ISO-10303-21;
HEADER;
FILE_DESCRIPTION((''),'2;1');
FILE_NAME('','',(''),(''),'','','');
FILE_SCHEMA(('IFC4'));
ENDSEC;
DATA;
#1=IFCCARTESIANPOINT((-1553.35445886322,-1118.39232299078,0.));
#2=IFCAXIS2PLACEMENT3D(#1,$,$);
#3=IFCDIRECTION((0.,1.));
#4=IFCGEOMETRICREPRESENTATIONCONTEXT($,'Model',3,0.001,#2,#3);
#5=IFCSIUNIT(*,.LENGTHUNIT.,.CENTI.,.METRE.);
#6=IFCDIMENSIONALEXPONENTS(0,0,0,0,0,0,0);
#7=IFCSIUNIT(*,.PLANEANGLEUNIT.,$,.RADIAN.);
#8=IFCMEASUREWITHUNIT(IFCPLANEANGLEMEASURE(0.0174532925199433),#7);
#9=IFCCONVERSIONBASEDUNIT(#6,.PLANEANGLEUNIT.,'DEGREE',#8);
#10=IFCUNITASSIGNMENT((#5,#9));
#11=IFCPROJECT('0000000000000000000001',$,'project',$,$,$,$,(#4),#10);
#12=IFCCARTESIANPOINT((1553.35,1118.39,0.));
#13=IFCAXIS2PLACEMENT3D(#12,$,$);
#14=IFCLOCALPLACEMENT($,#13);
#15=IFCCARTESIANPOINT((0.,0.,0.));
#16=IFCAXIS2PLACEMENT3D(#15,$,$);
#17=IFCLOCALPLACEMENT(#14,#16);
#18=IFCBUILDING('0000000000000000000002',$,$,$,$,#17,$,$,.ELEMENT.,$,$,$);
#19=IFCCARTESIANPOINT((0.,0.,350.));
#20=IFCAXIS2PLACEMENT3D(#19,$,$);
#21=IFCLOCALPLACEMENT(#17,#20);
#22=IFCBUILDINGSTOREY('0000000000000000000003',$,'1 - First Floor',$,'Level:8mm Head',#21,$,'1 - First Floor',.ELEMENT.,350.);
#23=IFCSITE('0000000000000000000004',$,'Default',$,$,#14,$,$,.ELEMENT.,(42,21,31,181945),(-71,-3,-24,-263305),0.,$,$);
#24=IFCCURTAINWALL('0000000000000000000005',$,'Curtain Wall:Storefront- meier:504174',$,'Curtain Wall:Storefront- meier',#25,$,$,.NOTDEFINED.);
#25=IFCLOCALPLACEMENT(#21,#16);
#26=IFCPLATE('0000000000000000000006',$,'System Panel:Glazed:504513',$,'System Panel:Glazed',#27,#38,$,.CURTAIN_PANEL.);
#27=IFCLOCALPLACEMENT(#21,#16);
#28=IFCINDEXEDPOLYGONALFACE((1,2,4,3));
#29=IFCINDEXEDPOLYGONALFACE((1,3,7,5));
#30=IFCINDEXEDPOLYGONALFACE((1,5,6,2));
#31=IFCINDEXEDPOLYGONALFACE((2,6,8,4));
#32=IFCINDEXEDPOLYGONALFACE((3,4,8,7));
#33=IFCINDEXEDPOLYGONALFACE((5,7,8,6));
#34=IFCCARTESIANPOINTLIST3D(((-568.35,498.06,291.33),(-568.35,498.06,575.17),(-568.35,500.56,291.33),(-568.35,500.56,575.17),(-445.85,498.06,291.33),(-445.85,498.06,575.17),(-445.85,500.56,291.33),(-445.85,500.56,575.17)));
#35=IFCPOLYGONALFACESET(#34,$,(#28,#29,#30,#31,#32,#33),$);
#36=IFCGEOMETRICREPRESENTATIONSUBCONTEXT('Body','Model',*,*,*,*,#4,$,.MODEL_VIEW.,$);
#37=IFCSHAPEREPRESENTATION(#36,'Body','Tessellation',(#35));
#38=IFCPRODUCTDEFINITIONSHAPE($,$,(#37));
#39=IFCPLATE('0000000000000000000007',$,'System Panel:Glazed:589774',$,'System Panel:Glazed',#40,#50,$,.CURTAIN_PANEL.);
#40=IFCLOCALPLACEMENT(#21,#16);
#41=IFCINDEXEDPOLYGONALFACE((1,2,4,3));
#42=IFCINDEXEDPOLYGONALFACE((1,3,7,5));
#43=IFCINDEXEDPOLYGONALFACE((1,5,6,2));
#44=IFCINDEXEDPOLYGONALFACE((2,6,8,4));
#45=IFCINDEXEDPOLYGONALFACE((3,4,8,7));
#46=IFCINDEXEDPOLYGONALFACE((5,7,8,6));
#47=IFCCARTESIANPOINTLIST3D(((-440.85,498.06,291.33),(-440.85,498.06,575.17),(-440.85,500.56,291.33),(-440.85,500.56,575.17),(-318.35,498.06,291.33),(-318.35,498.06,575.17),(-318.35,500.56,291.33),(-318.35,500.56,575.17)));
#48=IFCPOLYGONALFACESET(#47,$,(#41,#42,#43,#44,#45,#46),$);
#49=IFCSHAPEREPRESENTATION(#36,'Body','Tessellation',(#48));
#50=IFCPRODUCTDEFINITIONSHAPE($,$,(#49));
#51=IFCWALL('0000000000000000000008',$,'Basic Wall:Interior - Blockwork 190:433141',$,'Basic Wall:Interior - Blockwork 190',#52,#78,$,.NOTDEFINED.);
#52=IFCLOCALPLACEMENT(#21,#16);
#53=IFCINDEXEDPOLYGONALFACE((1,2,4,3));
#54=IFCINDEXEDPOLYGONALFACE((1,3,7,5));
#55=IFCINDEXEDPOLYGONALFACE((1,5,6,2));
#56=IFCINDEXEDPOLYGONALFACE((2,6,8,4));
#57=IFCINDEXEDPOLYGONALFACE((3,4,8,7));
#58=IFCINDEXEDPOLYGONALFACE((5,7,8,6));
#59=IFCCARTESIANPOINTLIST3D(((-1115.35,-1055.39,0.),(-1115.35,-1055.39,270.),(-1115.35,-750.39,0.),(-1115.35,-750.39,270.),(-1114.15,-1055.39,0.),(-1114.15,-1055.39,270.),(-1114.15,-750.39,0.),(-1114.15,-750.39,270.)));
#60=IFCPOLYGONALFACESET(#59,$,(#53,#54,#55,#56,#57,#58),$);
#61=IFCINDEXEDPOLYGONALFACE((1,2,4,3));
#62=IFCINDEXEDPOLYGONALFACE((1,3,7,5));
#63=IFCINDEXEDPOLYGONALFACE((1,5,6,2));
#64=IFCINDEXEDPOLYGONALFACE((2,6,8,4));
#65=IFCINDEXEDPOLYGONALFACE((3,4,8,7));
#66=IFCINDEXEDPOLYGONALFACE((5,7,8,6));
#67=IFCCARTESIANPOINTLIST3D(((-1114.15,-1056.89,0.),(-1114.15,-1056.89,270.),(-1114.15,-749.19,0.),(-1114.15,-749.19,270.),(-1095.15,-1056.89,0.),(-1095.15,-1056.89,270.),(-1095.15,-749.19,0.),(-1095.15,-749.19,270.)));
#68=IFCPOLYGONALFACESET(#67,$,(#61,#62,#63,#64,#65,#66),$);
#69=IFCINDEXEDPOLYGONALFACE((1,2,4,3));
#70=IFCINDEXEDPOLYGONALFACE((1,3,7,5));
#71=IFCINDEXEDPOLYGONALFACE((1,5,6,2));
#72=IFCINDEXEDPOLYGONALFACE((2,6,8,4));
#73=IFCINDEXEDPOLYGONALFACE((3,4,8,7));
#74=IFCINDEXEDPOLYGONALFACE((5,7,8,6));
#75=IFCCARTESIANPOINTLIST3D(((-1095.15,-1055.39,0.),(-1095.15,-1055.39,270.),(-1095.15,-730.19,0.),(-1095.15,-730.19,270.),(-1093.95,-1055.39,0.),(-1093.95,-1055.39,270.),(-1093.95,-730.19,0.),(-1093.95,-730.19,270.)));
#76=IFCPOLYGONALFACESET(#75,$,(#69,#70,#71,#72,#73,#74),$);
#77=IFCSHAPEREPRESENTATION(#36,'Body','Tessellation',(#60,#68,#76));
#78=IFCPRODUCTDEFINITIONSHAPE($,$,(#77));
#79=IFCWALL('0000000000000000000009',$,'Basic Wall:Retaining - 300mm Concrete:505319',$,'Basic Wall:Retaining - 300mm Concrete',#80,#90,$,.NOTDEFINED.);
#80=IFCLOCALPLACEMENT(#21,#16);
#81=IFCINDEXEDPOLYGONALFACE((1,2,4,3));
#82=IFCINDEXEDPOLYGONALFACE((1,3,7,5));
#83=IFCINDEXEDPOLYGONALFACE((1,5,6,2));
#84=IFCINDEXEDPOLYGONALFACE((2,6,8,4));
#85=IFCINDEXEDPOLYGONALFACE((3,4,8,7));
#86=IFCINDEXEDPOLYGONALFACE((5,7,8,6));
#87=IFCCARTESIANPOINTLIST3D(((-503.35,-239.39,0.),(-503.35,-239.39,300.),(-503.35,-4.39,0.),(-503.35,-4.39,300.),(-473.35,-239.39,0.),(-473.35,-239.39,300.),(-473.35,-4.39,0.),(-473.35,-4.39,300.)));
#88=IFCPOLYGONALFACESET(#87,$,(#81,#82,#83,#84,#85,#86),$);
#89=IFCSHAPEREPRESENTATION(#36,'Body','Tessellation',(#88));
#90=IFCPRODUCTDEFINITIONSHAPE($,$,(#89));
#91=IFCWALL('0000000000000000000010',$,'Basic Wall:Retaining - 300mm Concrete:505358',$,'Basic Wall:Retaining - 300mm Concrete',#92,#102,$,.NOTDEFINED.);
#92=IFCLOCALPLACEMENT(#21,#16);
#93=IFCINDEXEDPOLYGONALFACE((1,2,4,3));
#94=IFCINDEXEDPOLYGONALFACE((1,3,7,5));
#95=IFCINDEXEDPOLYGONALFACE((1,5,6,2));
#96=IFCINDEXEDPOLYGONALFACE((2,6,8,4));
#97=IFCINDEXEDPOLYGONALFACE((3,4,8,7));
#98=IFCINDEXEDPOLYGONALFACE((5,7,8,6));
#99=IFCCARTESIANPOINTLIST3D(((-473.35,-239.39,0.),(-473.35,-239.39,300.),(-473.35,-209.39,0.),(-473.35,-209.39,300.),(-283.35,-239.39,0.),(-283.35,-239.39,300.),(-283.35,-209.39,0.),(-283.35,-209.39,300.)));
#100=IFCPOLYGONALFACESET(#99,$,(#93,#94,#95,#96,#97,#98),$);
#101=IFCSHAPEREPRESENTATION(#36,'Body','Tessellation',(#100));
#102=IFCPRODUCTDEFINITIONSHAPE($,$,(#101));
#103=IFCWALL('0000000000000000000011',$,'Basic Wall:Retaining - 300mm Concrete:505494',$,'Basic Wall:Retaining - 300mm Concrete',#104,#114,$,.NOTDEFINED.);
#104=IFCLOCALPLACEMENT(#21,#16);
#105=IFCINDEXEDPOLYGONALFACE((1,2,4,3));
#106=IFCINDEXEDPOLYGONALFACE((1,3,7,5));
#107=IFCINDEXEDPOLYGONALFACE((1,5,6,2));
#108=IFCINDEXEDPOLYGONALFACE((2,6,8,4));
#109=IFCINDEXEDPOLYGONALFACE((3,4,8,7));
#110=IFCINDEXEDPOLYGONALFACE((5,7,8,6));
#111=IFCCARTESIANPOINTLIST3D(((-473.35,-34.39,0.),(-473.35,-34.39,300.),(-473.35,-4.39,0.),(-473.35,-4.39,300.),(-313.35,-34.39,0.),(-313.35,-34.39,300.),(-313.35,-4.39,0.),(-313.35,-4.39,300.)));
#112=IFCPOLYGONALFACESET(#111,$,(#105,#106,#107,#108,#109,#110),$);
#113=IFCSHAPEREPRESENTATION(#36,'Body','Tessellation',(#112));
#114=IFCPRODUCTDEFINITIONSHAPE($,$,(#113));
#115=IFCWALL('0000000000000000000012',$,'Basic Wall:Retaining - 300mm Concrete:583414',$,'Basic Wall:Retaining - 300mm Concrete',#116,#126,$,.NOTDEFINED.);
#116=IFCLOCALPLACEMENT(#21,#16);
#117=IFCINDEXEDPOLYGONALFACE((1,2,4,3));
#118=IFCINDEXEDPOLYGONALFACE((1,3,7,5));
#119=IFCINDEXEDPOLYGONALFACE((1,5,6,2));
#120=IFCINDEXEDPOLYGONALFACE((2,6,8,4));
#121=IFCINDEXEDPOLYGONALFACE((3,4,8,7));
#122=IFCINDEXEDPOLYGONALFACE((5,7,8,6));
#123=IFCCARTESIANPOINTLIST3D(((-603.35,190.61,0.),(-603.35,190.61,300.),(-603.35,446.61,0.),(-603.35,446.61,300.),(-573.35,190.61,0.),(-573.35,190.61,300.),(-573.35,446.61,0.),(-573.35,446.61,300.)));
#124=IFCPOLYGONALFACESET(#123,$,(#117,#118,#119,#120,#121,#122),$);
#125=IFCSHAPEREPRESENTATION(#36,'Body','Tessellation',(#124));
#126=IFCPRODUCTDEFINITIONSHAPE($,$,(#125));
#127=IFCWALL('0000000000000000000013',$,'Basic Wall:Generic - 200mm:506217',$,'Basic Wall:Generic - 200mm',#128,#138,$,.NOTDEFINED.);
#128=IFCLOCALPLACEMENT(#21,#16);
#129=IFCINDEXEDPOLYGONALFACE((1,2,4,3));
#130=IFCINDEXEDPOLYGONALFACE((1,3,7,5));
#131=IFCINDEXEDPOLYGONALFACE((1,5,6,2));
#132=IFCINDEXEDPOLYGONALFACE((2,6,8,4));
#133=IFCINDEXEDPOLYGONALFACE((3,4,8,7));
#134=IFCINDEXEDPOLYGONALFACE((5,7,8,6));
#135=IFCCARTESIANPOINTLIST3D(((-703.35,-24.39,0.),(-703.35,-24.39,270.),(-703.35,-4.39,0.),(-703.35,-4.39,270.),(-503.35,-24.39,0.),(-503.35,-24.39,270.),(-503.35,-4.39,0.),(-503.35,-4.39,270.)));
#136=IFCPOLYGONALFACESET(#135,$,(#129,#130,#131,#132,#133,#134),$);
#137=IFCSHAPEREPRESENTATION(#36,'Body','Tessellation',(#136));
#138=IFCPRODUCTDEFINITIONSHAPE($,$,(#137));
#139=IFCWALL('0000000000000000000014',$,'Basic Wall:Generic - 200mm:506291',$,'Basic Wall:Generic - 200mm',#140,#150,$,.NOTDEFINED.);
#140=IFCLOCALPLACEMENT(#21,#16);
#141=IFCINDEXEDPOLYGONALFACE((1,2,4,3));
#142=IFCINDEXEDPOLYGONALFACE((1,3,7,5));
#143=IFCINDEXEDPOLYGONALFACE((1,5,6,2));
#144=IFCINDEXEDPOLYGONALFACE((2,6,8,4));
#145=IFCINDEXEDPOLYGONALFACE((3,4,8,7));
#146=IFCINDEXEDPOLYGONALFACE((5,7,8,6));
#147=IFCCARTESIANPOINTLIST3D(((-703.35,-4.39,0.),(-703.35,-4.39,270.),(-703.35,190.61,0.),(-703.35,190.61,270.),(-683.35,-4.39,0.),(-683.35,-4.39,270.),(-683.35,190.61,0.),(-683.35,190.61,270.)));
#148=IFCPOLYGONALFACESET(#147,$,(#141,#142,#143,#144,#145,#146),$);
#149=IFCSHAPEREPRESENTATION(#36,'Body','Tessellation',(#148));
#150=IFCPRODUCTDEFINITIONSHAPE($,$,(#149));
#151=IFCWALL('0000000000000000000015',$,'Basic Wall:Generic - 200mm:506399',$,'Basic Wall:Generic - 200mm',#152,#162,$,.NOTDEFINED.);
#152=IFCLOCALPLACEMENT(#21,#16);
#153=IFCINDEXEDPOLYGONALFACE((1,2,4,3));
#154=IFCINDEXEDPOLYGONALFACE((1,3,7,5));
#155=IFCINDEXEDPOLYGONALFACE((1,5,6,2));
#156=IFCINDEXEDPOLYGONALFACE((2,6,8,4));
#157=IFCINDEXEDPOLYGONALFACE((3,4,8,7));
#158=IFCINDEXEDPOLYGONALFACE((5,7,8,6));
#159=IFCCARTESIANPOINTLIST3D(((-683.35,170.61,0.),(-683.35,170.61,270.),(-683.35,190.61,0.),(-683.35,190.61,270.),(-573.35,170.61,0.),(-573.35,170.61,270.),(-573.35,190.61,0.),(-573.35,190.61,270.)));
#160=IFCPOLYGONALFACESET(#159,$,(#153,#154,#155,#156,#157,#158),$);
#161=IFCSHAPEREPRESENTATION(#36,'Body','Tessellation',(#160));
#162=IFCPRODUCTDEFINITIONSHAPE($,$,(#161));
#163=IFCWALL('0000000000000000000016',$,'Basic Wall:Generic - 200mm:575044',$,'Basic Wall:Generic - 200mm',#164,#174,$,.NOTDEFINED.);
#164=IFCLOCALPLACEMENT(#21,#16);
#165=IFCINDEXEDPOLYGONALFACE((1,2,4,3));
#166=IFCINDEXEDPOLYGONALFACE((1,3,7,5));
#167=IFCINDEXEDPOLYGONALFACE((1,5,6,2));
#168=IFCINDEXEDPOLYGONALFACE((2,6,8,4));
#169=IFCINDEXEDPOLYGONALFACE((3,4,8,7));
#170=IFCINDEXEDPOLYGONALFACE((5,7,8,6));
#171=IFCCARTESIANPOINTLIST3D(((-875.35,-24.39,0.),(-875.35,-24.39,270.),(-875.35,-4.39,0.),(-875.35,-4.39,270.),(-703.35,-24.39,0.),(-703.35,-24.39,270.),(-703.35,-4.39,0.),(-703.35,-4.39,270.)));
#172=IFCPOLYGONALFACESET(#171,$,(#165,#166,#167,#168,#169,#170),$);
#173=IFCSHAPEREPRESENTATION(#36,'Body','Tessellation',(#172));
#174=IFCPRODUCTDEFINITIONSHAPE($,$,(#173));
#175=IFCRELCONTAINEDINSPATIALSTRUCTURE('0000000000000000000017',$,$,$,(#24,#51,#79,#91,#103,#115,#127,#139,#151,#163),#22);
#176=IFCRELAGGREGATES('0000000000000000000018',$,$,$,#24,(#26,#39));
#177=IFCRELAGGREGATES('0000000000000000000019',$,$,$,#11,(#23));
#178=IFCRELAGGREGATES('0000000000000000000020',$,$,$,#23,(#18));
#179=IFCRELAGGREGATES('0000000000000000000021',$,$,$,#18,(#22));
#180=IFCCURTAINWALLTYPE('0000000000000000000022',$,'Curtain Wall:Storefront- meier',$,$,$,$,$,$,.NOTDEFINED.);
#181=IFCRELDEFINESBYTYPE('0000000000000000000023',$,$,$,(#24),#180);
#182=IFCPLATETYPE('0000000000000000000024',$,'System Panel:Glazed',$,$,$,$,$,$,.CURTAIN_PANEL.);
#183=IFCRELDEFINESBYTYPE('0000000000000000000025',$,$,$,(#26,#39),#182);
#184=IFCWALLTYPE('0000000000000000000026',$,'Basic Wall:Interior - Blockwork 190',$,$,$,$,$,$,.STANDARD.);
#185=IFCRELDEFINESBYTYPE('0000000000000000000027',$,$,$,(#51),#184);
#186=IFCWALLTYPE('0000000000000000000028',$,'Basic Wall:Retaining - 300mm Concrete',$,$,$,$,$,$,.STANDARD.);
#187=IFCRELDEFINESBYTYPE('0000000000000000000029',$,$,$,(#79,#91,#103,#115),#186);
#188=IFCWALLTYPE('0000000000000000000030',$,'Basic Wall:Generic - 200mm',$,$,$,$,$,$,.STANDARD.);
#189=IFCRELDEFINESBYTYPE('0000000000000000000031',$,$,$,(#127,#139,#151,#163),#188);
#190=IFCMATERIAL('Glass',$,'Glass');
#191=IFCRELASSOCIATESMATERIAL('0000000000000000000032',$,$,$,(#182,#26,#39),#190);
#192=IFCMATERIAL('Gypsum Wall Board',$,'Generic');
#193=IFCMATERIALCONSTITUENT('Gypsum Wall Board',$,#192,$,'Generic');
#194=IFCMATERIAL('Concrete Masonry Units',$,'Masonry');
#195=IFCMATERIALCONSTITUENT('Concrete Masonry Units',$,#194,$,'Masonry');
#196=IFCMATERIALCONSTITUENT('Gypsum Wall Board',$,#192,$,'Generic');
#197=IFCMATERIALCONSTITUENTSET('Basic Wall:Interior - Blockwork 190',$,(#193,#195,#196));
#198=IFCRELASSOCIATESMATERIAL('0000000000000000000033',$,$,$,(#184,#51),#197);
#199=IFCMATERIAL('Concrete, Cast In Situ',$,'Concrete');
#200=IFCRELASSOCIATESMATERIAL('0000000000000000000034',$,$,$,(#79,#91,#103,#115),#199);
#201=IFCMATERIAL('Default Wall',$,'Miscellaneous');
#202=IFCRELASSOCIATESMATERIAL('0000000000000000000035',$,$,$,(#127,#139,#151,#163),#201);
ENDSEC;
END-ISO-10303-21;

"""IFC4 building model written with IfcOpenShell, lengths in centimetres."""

from ifc_helpers import new_model, entity, si_unit, converted_unit, direction, frame, origin, place, context, subcontext, project, spatial, indexed_curve, outline, extrude, source, transform, mapped, material, constituent, constituent_set, type_object, type_shapes, element, aggregate, save


model = new_model("IFC4")

# Units and contexts
model_context = context("Model", 3, precision=0.001, world=frame((-1553.35445886322, -1118.39232299078, 0.0)), true_north=direction((0.0, 1.0)))
body_context = subcontext(model_context, "Body", "Model", "MODEL_VIEW")
ifc_project = project(units=[si_unit("LENGTHUNIT", "METRE", prefix="CENTI"), converted_unit("PLANEANGLEUNIT", "DEGREE", entity("IfcPlaneAngleMeasure", 0.0174532925199433), si_unit("PLANEANGLEUNIT", "RADIAN"), dimensions=[0, 0, 0, 0, 0, 0, 0])], contexts=[model_context])

# Site, building, storey
site_placement = place(None, frame((1553.35, 1118.39, 0.0)))
site = spatial("IfcSite", under=ifc_project, at=site_placement, Name="Default", CompositionType="ELEMENT", RefLatitude=(42, 21, 31, 181945), RefLongitude=(-71, -3, -24, -263305), RefElevation=0.0)
building_placement = place(site_placement, origin())
building = spatial("IfcBuilding", under=site, at=building_placement, CompositionType="ELEMENT")
storey_placement = place(building_placement, frame((0.0, 0.0, 350.0)))
storey = spatial("IfcBuildingStorey", under=building, at=storey_placement, Name="1 - First Floor", ObjectType="Level:8mm Head", LongName="1 - First Floor", CompositionType="ELEMENT", Elevation=350.0)

# Curtain wall, plates
curtain_wall_type = type_object("IfcCurtainWallType", Name="Curtain Wall:Storefront- meier", PredefinedType="NOTDEFINED")
curtain_wall_placement = place(storey_placement, frame((0.0, 0.0, -350.0)))
curtain_wall = element("IfcCurtainWall", 1, at=curtain_wall_placement, inside=storey, type_object=curtain_wall_type, Name="Curtain Wall:Storefront- meier:504174", ObjectType="Curtain Wall:Storefront- meier", PredefinedType="NOTDEFINED")
ifc_material_1 = material(Name="Glass", Category="Glass")
plate_type_1 = type_object("IfcPlateType", Name="System Panel:Glazed", PredefinedType="CURTAIN_PANEL", material=ifc_material_1)
shared_shape_1 = source(origin(), body_context, "Body", "SweptSolid", [
    extrude(outline(indexed_curve([(-1.25, -61.25), (1.25, -61.25), (1.25, 61.25), (-1.25, 61.25), (-1.25, -61.25)], self_intersect=False)), frame((0.0, 3.7, 0.0), z_axis=(0.0, 0.0, 1.0), x_axis=(0.0, 1.0, 0.0)), (0.0, 0.0, 1.0), 283.83),
])
type_shapes(plate_type_1, [shared_shape_1])
plate_1_placement = place(curtain_wall_placement, frame((-507.1, 495.61, 641.33)))
plate_1 = element("IfcPlate", 2, at=plate_1_placement, type_object=plate_type_1, material=ifc_material_1, Name="System Panel:Glazed:504513", ObjectType="System Panel:Glazed", PredefinedType="CURTAIN_PANEL", context=body_context, shape_type="MappedRepresentation", body=[
    mapped(shared_shape_1, transform((0.0, 0.0, 0.0), scale=1.0)),
])
plate_2_placement = place(curtain_wall_placement, frame((-379.6, 495.61, 641.33)))
plate_2 = element("IfcPlate", 3, at=plate_2_placement, type_object=plate_type_1, material=ifc_material_1, Name="System Panel:Glazed:589774", ObjectType="System Panel:Glazed", PredefinedType="CURTAIN_PANEL", context=body_context, shape_type="MappedRepresentation", body=[
    mapped(shared_shape_1, transform((0.0, 0.0, 0.0), scale=1.0)),
])
aggregate(curtain_wall, [plate_1, plate_2])

# Shared definitions
ifc_material_2 = material(Name="Concrete Masonry Units", Category="Masonry")

# Shared definitions
ifc_material_3 = material(Name="Gypsum Wall Board", Category="Generic")
ifc_constituent_1 = constituent(ifc_material_3, Name="Gypsum Wall Board", Category="Generic")
ifc_constituent_2 = constituent(ifc_material_2, Name="Concrete Masonry Units", Category="Masonry")
ifc_constituent_3 = constituent(ifc_material_3, Name="Gypsum Wall Board", Category="Generic")
ifc_constituent_set_1 = constituent_set(constituents=[ifc_constituent_1, ifc_constituent_2, ifc_constituent_3], Name="Basic Wall:Interior - Blockwork 190")
wall_type_1 = type_object("IfcWallType", Name="Basic Wall:Interior - Blockwork 190", PredefinedType="STANDARD", material=ifc_constituent_set_1)

# Walls
wall_1_placement = place(storey_placement, frame((-1104.65, -750.39, 0.0), z_axis=(0.0, 0.0, 1.0), x_axis=(0.0, -1.0, 0.0)))
element("IfcWall", 4, at=wall_1_placement, inside=storey, type_object=wall_type_1, material=ifc_constituent_set_1, Name="Basic Wall:Interior - Blockwork 190:433141", ObjectType="Basic Wall:Interior - Blockwork 190", PredefinedType="NOTDEFINED", context=body_context, shape_type="SweptSolid", body=[
    extrude(outline(indexed_curve([(-0.6, -152.5), (0.6, -152.5), (0.6, 152.5), (-0.6, 152.5), (-0.6, -152.5)], self_intersect=False)), frame((152.5, -10.1, 0.0), z_axis=(0.0, 0.0, 1.0), x_axis=(0.0, 1.0, 0.0)), (0.0, 0.0, 1.0), 270.0),
    extrude(outline(indexed_curve([(-153.85, -9.5), (153.85, -9.5), (153.85, 9.5), (-153.85, 9.5), (-153.85, -9.5)], self_intersect=False)), frame((152.65, 0.0, 0.0)), (0.0, 0.0, 1.0), 270.0),
    extrude(outline(indexed_curve([(-0.6, -162.6), (0.6, -162.6), (0.6, 162.6), (-0.6, 162.6), (-0.6, -162.6)], self_intersect=False)), frame((142.4, 10.1, 0.0), z_axis=(0.0, 0.0, 1.0), x_axis=(0.0, -1.0, 0.0)), (0.0, 0.0, 1.0), 270.0),
])
ifc_material_4 = material(Name="Concrete, Cast In Situ", Category="Concrete")
wall_type_2 = type_object("IfcWallType", Name="Basic Wall:Retaining - 300mm Concrete", PredefinedType="STANDARD")
wall_2_placement = place(storey_placement, frame((-488.35, -4.39, 0.0), z_axis=(0.0, 0.0, 1.0), x_axis=(0.0, -1.0, 0.0)))
element("IfcWall", 5, at=wall_2_placement, inside=storey, type_object=wall_type_2, material=ifc_material_4, Name="Basic Wall:Retaining - 300mm Concrete:505319", ObjectType="Basic Wall:Retaining - 300mm Concrete", PredefinedType="NOTDEFINED", context=body_context, shape_type="SweptSolid", body=[
    extrude(outline(indexed_curve([(235.0, 15.0), (0.0, 15.0), (0.0, -15.0), (235.0, -15.0), (235.0, 15.0)], self_intersect=False)), origin(), (0.0, 0.0, 1.0), 300.0),
])
wall_3_placement = place(storey_placement, frame((-473.35, -224.39, 0.0)))
element("IfcWall", 6, at=wall_3_placement, inside=storey, type_object=wall_type_2, material=ifc_material_4, Name="Basic Wall:Retaining - 300mm Concrete:505358", ObjectType="Basic Wall:Retaining - 300mm Concrete", PredefinedType="NOTDEFINED", context=body_context, shape_type="SweptSolid", body=[
    extrude(outline(indexed_curve([(190.0, 15.0), (0.0, 15.0), (0.0, -15.0), (190.0, -15.0), (190.0, 15.0)], self_intersect=False)), origin(), (0.0, 0.0, 1.0), 300.0),
])
wall_4_placement = place(storey_placement, frame((-313.35, -19.39, 0.0), z_axis=(0.0, 0.0, 1.0), x_axis=(-1.0, 0.0, 0.0)))
element("IfcWall", 7, at=wall_4_placement, inside=storey, type_object=wall_type_2, material=ifc_material_4, Name="Basic Wall:Retaining - 300mm Concrete:505494", ObjectType="Basic Wall:Retaining - 300mm Concrete", PredefinedType="NOTDEFINED", context=body_context, shape_type="SweptSolid", body=[
    extrude(outline(indexed_curve([(160.0, 15.0), (0.0, 15.0), (0.0, -15.0), (160.0, -15.0), (160.0, 15.0)], self_intersect=False)), origin(), (0.0, 0.0, 1.0), 300.0),
])
wall_5_placement = place(storey_placement, frame((-588.35, 446.61, 0.0), z_axis=(0.0, 0.0, 1.0), x_axis=(0.0, -1.0, 0.0)))
element("IfcWall", 8, at=wall_5_placement, inside=storey, type_object=wall_type_2, material=ifc_material_4, Name="Basic Wall:Retaining - 300mm Concrete:583414", ObjectType="Basic Wall:Retaining - 300mm Concrete", PredefinedType="NOTDEFINED", context=body_context, shape_type="SweptSolid", body=[
    extrude(outline(indexed_curve([(256.0, 15.0), (0.0, 15.0), (0.0, -15.0), (256.0, -15.0), (256.0, 15.0)], self_intersect=False)), origin(), (0.0, 0.0, 1.0), 300.0),
])
ifc_material_5 = material(Name="Default Wall", Category="Miscellaneous")
wall_type_3 = type_object("IfcWallType", Name="Basic Wall:Generic - 200mm", PredefinedType="STANDARD")
wall_6_placement = place(storey_placement, frame((-503.35, -14.39, 0.0), z_axis=(0.0, 0.0, 1.0), x_axis=(-1.0, 0.0, 0.0)))
element("IfcWall", 9, at=wall_6_placement, inside=storey, type_object=wall_type_3, material=ifc_material_5, Name="Basic Wall:Generic - 200mm:506217", ObjectType="Basic Wall:Generic - 200mm", PredefinedType="NOTDEFINED", context=body_context, shape_type="SweptSolid", body=[
    extrude(outline(indexed_curve([(200.0, 10.0), (0.0, 10.0), (0.0, -10.0), (200.0, -10.0), (200.0, 10.0)], self_intersect=False)), origin(), (0.0, 0.0, 1.0), 270.0),
])
wall_7_placement = place(storey_placement, frame((-693.35, -4.39, 0.0), z_axis=(0.0, 0.0, 1.0), x_axis=(0.0, 1.0, 0.0)))
element("IfcWall", 10, at=wall_7_placement, inside=storey, type_object=wall_type_3, material=ifc_material_5, Name="Basic Wall:Generic - 200mm:506291", ObjectType="Basic Wall:Generic - 200mm", PredefinedType="NOTDEFINED", context=body_context, shape_type="SweptSolid", body=[
    extrude(outline(indexed_curve([(195.0, 10.0), (0.0, 10.0), (0.0, -10.0), (195.0, -10.0), (195.0, 10.0)], self_intersect=False)), origin(), (0.0, 0.0, 1.0), 270.0),
])
wall_8_placement = place(storey_placement, frame((-683.35, 180.61, 0.0)))
element("IfcWall", 11, at=wall_8_placement, inside=storey, type_object=wall_type_3, material=ifc_material_5, Name="Basic Wall:Generic - 200mm:506399", ObjectType="Basic Wall:Generic - 200mm", PredefinedType="NOTDEFINED", context=body_context, shape_type="SweptSolid", body=[
    extrude(outline(indexed_curve([(110.0, 10.0), (0.0, 10.0), (0.0, -10.0), (110.0, -10.0), (110.0, 10.0)], self_intersect=False)), origin(), (0.0, 0.0, 1.0), 270.0),
])
wall_9_placement = place(storey_placement, frame((-703.35, -14.39, 0.0), z_axis=(0.0, 0.0, 1.0), x_axis=(-1.0, 0.0, 0.0)))
element("IfcWall", 12, at=wall_9_placement, inside=storey, type_object=wall_type_3, material=ifc_material_5, Name="Basic Wall:Generic - 200mm:575044", ObjectType="Basic Wall:Generic - 200mm", PredefinedType="NOTDEFINED", context=body_context, shape_type="SweptSolid", body=[
    extrude(outline(indexed_curve([(172.0, 10.0), (0.0, 10.0), (0.0, -10.0), (172.0, -10.0), (172.0, 10.0)], self_intersect=False)), origin(), (0.0, 0.0, 1.0), 270.0),
])

save(model, "model.ifc")
